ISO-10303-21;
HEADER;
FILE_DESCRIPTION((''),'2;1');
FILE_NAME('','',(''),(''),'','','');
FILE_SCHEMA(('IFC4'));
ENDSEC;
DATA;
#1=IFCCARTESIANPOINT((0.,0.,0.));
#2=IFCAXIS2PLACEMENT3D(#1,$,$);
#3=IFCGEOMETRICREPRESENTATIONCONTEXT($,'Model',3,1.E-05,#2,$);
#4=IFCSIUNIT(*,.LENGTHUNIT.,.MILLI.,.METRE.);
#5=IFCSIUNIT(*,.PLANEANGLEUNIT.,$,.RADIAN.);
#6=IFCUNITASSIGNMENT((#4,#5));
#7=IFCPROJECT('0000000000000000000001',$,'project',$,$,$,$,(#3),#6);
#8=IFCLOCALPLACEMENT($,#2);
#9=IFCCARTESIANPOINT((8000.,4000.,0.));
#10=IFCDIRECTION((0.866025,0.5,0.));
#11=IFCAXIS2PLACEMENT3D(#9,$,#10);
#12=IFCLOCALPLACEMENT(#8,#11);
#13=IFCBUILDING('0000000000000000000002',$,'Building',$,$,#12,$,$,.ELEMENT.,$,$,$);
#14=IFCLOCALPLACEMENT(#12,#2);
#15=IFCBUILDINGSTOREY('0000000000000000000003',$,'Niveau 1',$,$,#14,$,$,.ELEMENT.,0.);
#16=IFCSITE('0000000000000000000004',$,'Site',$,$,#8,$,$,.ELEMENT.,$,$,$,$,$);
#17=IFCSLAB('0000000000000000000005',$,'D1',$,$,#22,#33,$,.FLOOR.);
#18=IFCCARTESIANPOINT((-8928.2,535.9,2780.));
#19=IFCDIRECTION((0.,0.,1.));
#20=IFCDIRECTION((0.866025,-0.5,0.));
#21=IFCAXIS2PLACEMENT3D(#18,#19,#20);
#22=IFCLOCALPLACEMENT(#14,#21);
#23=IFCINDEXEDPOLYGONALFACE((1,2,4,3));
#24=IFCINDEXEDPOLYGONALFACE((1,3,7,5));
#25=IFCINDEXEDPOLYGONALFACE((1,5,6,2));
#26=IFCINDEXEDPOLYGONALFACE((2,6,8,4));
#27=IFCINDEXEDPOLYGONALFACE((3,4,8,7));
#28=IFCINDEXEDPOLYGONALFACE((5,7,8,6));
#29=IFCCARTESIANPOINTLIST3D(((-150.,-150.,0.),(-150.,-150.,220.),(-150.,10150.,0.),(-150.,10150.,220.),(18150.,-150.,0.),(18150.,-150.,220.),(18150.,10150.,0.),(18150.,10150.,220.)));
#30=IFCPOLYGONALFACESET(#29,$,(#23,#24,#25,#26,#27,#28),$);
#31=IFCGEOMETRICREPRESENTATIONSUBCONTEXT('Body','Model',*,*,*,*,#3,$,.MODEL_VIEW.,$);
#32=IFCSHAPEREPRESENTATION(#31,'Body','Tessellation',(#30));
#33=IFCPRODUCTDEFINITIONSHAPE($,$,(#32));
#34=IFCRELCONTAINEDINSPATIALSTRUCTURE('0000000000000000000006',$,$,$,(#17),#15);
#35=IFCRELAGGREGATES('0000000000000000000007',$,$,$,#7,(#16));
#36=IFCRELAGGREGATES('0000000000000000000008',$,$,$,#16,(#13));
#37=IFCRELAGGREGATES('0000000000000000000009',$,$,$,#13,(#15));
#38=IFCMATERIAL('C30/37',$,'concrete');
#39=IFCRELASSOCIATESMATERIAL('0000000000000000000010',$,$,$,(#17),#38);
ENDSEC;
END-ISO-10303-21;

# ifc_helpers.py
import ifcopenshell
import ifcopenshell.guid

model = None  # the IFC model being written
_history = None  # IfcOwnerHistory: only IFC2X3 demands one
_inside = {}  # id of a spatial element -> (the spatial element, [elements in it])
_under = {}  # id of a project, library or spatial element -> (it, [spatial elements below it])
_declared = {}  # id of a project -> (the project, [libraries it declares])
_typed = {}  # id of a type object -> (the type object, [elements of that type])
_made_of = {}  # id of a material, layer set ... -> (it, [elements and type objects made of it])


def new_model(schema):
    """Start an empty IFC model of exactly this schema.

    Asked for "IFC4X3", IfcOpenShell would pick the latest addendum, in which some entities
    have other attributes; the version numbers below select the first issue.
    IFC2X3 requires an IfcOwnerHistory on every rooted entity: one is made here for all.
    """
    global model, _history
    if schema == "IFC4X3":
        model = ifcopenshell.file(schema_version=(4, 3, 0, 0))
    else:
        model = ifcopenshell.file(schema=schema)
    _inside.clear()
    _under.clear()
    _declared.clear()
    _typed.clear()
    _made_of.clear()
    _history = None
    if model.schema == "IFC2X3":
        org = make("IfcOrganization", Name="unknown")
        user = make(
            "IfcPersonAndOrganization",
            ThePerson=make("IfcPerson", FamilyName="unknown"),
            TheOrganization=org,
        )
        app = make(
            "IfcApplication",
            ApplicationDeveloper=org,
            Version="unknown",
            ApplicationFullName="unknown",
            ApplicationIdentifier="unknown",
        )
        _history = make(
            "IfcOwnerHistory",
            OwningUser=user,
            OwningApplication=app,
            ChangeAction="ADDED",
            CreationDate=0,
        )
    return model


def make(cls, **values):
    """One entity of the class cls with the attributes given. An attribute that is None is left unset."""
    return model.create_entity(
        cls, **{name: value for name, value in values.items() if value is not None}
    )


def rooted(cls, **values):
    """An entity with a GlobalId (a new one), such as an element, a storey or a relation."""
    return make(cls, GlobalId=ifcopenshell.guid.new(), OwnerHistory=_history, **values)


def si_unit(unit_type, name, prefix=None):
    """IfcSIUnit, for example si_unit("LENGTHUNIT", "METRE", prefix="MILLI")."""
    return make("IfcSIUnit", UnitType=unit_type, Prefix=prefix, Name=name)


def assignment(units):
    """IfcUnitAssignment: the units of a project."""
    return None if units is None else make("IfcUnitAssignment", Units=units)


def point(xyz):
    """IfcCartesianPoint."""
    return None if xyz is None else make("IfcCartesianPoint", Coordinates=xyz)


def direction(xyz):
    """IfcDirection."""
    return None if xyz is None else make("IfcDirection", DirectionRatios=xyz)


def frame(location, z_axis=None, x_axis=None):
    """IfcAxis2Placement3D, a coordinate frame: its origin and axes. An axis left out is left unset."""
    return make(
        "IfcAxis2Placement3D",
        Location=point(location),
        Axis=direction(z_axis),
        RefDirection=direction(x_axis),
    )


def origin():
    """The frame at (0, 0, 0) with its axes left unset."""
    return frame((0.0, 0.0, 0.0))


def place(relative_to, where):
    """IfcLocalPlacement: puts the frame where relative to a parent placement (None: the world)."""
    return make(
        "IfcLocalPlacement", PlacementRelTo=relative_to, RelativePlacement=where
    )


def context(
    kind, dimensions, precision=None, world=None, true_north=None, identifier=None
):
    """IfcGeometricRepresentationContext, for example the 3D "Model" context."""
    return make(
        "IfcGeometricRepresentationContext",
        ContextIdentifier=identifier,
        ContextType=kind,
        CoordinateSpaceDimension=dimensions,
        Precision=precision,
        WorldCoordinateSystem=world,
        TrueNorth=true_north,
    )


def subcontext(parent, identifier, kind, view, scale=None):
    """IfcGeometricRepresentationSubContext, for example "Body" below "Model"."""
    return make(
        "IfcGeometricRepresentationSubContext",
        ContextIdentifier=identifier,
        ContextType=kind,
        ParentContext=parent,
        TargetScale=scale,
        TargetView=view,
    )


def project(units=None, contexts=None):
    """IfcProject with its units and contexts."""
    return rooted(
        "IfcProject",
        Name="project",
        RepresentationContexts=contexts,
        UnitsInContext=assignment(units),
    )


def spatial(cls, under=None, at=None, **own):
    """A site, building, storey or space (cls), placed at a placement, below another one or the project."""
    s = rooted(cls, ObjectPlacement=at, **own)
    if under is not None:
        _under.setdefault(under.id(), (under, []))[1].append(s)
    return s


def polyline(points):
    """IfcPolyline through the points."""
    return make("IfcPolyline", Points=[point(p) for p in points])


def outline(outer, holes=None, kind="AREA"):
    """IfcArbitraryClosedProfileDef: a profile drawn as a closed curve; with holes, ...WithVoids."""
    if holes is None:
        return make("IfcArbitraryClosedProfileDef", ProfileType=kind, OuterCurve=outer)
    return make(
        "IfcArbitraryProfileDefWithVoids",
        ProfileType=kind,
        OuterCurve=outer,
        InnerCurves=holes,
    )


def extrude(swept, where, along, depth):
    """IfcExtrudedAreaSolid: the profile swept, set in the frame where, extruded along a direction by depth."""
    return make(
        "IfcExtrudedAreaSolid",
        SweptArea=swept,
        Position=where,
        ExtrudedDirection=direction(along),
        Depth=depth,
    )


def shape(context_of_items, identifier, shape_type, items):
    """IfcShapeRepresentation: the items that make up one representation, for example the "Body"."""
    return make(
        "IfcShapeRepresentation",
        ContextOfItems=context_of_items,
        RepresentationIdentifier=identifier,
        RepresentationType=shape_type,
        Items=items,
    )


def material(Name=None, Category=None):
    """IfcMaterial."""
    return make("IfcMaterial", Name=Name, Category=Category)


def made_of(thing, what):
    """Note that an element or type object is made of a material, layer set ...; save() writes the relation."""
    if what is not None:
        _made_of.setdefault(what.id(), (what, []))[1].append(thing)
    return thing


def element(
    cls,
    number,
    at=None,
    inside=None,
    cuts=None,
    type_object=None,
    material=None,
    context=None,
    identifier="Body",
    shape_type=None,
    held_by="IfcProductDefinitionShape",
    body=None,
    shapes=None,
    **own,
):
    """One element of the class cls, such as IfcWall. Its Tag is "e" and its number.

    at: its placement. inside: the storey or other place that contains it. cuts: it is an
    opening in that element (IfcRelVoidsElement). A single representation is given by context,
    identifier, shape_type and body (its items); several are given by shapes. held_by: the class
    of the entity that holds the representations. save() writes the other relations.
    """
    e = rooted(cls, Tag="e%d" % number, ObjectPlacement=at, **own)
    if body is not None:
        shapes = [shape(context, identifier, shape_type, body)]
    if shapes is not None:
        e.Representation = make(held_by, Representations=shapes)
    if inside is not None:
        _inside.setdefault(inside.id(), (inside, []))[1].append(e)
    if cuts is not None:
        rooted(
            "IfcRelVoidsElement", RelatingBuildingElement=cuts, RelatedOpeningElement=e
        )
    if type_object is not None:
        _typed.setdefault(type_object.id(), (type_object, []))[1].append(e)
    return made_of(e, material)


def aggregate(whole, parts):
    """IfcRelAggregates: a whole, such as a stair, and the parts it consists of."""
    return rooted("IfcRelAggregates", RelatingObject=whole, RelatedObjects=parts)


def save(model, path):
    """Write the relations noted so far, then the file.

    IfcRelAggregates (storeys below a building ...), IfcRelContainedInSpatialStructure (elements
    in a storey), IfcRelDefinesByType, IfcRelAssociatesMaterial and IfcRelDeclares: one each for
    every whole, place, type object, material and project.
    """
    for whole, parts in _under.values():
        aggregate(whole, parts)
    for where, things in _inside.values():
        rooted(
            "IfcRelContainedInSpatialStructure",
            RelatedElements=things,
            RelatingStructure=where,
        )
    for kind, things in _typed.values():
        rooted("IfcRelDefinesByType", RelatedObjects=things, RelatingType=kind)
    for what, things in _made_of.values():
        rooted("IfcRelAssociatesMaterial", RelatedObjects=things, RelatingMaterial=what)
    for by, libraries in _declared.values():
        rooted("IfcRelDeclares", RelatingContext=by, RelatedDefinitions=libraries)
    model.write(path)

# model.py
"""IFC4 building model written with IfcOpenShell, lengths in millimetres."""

from ifc_helpers import new_model, si_unit, frame, origin, place, context, subcontext, project, spatial, polyline, outline, extrude, material, element, save


model = new_model("IFC4")

# Units and contexts
model_context = context("Model", 3, precision=1e-05, world=origin())
body_context = subcontext(model_context, "Body", "Model", "MODEL_VIEW")
ifc_project = project(units=[si_unit("LENGTHUNIT", "METRE", prefix="MILLI"), si_unit("PLANEANGLEUNIT", "RADIAN")], contexts=[model_context])

# Site, building, storey
site_placement = place(None, origin())
site = spatial("IfcSite", under=ifc_project, at=site_placement, Name="Site", CompositionType="ELEMENT")
building_placement = place(site_placement, frame((8000.0, 4000.0, 0.0), x_axis=(0.866025, 0.5, 0.0)))
building = spatial("IfcBuilding", under=site, at=building_placement, Name="Building", CompositionType="ELEMENT")
storey_placement = place(building_placement, origin())
storey = spatial("IfcBuildingStorey", under=building, at=storey_placement, Name="Niveau 1", CompositionType="ELEMENT", Elevation=0.0)

# Shared definitions
ifc_material = material(Name="C30/37", Category="concrete")

# Slab
slab_placement = place(storey_placement, frame((-8928.2, 535.9, 2780.0), z_axis=(0.0, 0.0, 1.0), x_axis=(0.866025, -0.5, 0.0)))
element("IfcSlab", 1, at=slab_placement, inside=storey, material=ifc_material, Name="D1", PredefinedType="FLOOR", context=body_context, shape_type="SweptSolid", body=[
    extrude(outline(polyline([(-150.0, -150.0), (18150.0, -150.0), (18150.0, 10150.0), (-150.0, 10150.0), (-150.0, -150.0)])), origin(), (0.0, 0.0, 1.0), 220.0),
])

save(model, "model.ifc")
